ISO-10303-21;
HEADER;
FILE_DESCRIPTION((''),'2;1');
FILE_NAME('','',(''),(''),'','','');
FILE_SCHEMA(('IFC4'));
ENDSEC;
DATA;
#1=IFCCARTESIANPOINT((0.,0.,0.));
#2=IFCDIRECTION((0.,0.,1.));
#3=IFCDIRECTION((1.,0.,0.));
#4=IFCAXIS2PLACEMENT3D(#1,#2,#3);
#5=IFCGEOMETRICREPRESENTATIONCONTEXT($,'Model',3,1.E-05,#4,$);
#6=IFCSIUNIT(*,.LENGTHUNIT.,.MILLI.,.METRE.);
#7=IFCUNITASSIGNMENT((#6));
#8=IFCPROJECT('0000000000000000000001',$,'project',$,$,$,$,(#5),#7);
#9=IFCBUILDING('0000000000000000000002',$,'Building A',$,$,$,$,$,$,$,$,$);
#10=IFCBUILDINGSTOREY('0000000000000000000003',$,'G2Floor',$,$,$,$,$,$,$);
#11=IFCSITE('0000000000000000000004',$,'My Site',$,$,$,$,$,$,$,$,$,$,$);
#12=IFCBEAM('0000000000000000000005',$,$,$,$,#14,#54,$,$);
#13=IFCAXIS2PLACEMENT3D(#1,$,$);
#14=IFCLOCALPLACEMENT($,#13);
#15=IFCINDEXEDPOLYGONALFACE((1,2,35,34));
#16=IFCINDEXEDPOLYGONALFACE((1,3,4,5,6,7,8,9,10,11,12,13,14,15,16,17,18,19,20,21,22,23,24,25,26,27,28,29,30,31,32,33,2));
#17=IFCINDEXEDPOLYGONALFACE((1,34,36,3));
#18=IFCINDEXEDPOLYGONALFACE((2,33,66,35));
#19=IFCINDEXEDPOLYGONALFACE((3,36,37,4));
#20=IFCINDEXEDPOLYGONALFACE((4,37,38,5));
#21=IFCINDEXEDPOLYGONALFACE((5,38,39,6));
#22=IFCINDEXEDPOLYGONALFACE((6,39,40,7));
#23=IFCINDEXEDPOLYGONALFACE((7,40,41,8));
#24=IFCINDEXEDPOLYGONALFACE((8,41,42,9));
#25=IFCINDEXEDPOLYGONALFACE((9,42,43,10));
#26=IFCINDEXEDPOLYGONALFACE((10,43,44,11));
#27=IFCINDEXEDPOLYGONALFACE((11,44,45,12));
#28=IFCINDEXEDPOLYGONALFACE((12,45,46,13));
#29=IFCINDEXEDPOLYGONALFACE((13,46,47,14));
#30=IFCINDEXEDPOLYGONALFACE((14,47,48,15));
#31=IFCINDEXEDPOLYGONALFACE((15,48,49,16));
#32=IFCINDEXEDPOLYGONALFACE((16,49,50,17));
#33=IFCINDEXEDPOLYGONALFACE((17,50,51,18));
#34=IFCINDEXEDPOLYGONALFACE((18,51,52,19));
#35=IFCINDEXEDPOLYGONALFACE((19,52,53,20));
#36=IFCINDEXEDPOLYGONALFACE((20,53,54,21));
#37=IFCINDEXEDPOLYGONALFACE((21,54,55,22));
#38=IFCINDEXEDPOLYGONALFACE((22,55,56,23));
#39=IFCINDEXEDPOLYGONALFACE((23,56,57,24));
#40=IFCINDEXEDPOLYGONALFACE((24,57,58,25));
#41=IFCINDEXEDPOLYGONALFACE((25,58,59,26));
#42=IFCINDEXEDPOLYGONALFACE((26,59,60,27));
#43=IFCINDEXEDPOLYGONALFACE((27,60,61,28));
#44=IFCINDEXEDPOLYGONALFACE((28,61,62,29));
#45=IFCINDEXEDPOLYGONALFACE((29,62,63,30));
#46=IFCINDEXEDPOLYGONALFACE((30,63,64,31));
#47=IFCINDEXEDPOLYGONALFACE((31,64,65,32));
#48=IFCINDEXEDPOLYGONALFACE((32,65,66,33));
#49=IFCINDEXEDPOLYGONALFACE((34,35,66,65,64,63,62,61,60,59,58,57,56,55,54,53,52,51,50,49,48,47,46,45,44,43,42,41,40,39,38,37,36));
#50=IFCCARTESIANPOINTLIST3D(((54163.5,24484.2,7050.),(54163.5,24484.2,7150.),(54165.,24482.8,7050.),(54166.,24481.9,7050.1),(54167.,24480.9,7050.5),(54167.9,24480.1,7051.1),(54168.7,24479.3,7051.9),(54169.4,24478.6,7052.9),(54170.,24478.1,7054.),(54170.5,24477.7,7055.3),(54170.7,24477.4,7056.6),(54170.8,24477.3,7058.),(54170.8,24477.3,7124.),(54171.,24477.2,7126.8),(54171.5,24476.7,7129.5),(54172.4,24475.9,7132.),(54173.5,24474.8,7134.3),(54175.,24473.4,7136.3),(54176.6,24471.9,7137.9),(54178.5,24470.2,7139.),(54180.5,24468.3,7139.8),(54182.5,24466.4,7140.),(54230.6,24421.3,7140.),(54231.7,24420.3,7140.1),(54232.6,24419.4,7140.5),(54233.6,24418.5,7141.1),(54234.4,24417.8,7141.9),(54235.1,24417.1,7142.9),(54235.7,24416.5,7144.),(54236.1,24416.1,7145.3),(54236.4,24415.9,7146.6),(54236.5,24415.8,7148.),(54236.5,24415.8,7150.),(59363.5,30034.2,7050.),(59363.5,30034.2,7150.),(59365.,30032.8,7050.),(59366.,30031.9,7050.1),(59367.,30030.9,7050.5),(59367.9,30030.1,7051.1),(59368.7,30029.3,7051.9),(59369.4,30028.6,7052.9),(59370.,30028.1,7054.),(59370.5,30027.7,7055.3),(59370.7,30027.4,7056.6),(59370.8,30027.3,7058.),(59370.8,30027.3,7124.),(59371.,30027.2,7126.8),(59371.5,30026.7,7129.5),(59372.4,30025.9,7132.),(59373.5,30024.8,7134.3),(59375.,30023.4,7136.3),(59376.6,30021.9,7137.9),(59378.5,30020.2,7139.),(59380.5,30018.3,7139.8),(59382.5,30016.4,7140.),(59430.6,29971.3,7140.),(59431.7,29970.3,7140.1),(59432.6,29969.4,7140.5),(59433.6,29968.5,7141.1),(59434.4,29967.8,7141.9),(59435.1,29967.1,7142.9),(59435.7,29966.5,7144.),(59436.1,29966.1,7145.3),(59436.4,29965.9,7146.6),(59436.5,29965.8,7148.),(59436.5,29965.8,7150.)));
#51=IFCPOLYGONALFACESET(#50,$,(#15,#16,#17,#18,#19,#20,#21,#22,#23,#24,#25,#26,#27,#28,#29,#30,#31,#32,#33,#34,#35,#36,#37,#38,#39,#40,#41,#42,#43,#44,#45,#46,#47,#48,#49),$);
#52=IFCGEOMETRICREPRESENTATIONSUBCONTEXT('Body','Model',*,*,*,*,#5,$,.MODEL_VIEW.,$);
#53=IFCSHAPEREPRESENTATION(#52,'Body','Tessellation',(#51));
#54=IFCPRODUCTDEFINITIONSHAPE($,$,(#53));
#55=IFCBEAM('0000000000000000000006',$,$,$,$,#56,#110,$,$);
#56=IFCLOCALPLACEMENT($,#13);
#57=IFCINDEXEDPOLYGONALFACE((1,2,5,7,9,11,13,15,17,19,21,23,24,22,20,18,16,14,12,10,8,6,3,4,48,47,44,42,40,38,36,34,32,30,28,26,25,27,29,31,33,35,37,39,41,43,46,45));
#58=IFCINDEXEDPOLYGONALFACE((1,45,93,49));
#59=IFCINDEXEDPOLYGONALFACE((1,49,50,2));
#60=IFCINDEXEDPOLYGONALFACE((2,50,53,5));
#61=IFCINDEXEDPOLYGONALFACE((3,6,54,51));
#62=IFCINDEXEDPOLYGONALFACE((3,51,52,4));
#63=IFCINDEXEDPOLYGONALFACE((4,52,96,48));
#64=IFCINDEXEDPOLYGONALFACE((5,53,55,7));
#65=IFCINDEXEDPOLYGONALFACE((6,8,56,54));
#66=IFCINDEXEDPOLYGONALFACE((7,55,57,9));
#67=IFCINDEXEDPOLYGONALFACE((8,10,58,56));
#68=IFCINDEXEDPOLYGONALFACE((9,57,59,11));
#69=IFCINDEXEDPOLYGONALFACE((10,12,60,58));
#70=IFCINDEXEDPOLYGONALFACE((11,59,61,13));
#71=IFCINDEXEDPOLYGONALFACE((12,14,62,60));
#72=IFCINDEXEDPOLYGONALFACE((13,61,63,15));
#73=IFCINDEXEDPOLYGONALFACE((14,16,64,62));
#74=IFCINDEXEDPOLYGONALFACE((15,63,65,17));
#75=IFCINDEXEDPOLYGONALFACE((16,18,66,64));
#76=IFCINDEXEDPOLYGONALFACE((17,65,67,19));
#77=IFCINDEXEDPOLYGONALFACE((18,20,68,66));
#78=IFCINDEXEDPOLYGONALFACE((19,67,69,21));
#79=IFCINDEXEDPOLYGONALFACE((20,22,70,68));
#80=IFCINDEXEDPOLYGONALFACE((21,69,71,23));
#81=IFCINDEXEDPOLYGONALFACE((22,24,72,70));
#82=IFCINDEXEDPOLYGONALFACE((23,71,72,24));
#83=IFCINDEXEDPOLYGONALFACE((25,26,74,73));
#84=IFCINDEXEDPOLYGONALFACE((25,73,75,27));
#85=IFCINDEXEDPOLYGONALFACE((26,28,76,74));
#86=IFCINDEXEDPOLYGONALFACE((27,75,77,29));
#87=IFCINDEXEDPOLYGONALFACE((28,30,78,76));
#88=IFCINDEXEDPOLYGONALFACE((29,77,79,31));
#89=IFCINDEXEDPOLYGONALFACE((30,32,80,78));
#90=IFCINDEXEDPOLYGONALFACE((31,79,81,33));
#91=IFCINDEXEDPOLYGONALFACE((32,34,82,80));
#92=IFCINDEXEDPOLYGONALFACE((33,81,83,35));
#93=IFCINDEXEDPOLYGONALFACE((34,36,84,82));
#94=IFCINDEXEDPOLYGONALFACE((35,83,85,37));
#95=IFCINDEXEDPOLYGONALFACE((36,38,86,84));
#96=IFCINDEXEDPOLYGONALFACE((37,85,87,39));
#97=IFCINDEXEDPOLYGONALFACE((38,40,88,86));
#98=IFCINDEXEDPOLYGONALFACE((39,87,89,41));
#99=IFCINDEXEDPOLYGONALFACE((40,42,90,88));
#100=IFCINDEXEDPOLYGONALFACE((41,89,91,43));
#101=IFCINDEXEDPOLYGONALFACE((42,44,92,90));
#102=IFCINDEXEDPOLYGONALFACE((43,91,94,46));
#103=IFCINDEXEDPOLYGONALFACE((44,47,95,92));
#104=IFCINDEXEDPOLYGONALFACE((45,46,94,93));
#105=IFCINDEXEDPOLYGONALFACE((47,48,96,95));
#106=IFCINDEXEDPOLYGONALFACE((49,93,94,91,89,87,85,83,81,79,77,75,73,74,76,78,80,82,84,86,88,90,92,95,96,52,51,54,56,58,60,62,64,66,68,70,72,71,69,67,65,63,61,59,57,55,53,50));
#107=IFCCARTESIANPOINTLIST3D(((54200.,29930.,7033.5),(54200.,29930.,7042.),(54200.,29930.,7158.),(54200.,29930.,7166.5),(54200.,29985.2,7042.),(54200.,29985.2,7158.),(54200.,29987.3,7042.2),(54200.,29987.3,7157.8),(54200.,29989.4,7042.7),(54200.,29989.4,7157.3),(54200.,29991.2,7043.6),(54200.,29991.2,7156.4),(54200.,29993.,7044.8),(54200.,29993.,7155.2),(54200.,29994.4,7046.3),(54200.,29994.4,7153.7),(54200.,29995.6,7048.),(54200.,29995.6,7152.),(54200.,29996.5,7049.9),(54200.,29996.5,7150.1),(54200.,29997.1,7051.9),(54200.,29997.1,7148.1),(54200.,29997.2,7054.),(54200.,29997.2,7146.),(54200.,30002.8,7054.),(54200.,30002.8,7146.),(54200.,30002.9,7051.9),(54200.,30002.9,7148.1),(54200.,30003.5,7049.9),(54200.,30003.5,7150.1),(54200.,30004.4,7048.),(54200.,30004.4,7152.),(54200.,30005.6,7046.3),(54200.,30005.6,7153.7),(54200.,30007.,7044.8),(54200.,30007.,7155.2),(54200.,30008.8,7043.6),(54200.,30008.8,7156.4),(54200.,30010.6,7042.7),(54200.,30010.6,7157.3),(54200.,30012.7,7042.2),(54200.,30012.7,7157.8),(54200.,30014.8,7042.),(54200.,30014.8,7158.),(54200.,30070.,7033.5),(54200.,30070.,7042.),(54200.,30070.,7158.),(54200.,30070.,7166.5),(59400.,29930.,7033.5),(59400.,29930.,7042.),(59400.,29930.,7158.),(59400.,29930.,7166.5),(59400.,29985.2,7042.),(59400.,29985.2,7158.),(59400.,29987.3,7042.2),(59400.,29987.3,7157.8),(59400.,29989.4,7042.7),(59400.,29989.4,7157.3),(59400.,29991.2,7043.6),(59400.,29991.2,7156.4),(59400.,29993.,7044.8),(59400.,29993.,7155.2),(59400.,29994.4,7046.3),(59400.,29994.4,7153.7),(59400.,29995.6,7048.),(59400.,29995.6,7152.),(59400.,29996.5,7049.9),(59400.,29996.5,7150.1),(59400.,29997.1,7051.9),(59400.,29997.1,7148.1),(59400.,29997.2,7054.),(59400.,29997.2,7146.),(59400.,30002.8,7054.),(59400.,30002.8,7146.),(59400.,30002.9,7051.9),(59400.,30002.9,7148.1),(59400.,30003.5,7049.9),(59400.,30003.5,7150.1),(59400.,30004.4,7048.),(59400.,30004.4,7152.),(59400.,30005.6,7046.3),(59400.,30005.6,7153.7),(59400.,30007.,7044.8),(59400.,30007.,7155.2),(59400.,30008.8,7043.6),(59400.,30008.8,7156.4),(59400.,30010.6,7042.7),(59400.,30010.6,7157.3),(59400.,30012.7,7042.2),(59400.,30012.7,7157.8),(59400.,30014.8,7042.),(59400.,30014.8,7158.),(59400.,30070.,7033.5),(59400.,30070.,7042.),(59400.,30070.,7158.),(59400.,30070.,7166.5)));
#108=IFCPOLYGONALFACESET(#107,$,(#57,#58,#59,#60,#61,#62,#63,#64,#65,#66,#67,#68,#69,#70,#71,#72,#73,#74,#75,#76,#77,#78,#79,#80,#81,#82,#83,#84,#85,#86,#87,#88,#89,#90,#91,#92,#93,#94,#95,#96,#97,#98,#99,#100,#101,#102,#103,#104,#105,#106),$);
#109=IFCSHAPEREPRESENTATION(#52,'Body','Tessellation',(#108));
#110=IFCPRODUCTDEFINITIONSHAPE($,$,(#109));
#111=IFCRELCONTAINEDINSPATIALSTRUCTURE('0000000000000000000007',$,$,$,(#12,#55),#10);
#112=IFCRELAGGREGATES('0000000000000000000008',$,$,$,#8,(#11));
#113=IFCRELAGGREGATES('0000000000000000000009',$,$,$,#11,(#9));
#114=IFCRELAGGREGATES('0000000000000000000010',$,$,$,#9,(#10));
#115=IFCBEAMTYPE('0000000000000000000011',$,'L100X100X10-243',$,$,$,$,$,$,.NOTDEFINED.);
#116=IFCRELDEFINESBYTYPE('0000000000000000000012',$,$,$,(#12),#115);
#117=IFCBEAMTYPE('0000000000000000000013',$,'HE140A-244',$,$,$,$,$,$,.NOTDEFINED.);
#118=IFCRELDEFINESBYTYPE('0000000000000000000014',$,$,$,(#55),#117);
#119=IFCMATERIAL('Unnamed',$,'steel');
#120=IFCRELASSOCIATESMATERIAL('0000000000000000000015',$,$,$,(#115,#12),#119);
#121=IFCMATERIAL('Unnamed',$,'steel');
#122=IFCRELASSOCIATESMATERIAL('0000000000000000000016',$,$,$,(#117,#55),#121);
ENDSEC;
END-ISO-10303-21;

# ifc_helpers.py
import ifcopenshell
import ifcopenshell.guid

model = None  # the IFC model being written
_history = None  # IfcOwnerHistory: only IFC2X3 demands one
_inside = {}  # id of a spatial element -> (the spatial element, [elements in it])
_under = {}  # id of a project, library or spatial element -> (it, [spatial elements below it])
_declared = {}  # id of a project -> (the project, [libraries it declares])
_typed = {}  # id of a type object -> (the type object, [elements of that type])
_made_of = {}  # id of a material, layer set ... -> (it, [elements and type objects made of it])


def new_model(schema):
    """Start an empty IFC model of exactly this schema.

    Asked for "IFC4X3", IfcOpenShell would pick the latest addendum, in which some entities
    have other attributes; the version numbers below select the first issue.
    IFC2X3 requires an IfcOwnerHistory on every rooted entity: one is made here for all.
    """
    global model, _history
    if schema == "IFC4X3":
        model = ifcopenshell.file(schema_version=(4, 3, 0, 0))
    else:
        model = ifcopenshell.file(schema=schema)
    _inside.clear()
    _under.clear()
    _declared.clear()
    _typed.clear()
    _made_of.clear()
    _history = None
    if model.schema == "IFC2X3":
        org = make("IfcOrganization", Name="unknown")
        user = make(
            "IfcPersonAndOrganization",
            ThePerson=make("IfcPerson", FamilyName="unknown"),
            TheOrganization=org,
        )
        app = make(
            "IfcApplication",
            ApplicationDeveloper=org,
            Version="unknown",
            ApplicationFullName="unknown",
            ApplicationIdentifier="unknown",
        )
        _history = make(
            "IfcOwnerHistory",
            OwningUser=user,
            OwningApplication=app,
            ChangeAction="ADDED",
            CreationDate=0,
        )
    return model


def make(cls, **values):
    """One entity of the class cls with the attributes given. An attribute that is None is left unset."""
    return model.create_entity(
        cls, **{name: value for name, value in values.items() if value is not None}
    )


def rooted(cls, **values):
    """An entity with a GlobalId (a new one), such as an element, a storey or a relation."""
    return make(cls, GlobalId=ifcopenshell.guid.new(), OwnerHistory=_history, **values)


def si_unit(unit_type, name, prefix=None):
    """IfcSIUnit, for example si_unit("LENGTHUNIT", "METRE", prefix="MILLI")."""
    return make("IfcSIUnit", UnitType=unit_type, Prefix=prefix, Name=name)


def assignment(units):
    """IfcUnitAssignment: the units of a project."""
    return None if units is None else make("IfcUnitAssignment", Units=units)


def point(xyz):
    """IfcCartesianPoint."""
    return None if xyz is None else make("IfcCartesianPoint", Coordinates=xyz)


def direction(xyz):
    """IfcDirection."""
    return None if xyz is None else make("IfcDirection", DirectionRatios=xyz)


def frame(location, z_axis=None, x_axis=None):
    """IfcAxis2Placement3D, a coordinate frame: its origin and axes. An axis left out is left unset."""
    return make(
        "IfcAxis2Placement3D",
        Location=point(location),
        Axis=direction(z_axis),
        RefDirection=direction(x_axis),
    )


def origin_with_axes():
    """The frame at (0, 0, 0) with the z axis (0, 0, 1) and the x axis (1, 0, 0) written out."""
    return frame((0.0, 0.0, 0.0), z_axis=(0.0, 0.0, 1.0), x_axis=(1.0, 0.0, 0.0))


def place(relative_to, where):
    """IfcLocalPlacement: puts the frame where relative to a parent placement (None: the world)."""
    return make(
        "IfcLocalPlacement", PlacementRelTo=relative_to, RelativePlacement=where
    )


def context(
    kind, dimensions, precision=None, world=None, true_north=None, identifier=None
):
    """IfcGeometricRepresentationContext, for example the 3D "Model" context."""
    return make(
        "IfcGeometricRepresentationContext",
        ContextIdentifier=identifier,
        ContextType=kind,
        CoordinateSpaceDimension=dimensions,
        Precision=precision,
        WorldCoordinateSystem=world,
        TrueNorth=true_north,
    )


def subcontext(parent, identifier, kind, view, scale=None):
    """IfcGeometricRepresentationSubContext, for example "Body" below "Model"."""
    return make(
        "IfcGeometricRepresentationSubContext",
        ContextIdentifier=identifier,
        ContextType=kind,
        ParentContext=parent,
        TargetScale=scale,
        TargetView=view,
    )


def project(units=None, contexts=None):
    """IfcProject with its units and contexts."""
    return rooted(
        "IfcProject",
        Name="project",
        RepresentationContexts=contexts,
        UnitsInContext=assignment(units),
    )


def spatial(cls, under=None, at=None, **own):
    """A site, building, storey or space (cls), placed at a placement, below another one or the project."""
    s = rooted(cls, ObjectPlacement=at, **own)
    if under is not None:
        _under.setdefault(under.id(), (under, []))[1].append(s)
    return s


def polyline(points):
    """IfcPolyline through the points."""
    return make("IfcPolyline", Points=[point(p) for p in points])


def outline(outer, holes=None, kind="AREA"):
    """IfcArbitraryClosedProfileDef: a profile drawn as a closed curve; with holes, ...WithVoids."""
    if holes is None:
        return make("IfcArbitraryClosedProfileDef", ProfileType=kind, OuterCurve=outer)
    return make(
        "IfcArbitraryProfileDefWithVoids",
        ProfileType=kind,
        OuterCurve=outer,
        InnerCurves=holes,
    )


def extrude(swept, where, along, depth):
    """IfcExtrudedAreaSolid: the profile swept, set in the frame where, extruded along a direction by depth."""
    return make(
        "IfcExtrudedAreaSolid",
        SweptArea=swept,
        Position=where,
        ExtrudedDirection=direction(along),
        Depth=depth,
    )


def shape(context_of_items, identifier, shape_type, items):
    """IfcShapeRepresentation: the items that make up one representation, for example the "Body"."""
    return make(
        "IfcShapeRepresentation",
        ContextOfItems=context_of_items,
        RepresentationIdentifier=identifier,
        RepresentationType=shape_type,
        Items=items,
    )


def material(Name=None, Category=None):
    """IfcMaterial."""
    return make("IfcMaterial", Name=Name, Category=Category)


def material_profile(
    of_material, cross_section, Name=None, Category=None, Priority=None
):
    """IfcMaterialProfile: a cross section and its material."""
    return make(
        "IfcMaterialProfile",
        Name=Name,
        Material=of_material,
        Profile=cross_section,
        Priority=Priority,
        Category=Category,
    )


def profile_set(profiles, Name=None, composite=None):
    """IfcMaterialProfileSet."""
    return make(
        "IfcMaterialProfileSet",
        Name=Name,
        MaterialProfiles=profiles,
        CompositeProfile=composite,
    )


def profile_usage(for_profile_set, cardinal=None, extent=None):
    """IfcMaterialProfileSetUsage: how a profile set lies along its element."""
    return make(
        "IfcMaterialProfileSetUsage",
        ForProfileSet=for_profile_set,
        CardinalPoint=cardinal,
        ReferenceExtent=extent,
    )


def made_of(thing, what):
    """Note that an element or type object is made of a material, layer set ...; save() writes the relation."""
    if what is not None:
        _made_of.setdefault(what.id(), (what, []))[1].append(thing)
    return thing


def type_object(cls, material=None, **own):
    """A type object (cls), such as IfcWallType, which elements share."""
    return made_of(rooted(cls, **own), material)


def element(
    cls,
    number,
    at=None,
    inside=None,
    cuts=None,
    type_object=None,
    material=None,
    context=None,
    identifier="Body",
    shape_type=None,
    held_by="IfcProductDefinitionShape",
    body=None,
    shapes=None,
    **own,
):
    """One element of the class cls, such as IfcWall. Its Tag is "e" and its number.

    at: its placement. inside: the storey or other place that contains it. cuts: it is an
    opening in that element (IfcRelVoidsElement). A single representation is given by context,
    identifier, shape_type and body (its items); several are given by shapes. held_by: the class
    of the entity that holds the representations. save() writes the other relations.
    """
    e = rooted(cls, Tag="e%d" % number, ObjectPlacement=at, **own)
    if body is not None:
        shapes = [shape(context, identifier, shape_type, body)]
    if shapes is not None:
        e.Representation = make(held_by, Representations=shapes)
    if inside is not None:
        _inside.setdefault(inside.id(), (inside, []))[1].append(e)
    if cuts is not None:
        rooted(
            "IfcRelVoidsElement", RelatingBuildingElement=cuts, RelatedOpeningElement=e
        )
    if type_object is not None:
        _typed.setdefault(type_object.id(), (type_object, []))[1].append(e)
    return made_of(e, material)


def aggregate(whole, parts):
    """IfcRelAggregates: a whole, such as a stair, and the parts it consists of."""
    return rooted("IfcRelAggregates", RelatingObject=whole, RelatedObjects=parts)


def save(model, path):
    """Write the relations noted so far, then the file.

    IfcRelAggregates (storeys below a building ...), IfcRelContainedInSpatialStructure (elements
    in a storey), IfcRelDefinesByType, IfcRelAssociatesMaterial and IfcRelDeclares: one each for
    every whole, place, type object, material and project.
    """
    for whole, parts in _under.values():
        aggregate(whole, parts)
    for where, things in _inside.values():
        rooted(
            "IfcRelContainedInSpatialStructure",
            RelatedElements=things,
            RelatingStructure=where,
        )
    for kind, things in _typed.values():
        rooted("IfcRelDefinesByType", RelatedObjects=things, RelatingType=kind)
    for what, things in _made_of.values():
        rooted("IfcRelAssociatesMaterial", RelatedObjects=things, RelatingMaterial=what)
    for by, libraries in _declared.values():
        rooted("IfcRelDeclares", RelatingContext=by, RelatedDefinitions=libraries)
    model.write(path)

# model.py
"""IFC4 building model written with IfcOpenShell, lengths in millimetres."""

from ifc_helpers import new_model, si_unit, frame, origin_with_axes, place, context, subcontext, project, spatial, polyline, outline, extrude, material, material_profile, profile_set, profile_usage, type_object, element, save


model = new_model("IFC4")

# Units and contexts
model_context = context("Model", 3, precision=1e-05, world=origin_with_axes())
body_context = subcontext(model_context, "Body", "Model", "MODEL_VIEW")
ifc_project = project(units=[si_unit("LENGTHUNIT", "METRE", prefix="MILLI")], contexts=[model_context])

# Site, building, storey
site = spatial("IfcSite", under=ifc_project, Name="My Site")
building = spatial("IfcBuilding", under=site, Name="Building A")
storey = spatial("IfcBuildingStorey", under=building, Name="G2Floor")

# Beams
ifc_material_1 = material(Name="Unnamed", Category="steel")
ifc_material_profile_1 = material_profile(ifc_material_1, outline(polyline([(-50.0, -50.0), (50.0, -50.0), (50.0, -50.0), (50.0, -48.0), (50.0, -48.0), (49.9, -46.6), (49.9, -46.6), (49.5, -45.3), (49.5, -45.3), (48.9, -44.0), (48.9, -44.0), (48.1, -42.9), (48.1, -42.9), (47.1, -41.9), (47.1, -41.9), (46.0, -41.1), (46.0, -41.1), (44.7, -40.5), (44.7, -40.5), (43.4, -40.1), (43.4, -40.1), (42.0, -40.0), (42.0, -40.0), (-24.0, -40.0), (-24.0, -40.0), (-26.8, -39.8), (-26.8, -39.8), (-29.5, -39.0), (-29.5, -39.0), (-32.0, -37.9), (-32.0, -37.9), (-34.3, -36.3), (-34.3, -36.3), (-36.3, -34.3), (-36.3, -34.3), (-37.9, -32.0), (-37.9, -32.0), (-39.0, -29.5), (-39.0, -29.5), (-39.8, -26.8), (-39.8, -26.8), (-40.0, -24.0), (-40.0, -24.0), (-40.0, 42.0), (-40.0, 42.0), (-40.1, 43.4), (-40.1, 43.4), (-40.5, 44.7), (-40.5, 44.7), (-41.1, 46.0), (-41.1, 46.0), (-41.9, 47.1), (-41.9, 47.1), (-42.9, 48.1), (-42.9, 48.1), (-44.0, 48.9), (-44.0, 48.9), (-45.3, 49.5), (-45.3, 49.5), (-46.6, 49.9), (-46.6, 49.9), (-48.0, 50.0), (-48.0, 50.0), (-50.0, 50.0), (-50.0, 50.0), (-50.0, -50.0)])))
ifc_profile_set_1 = profile_set([ifc_material_profile_1], Name="L100X100X10-243")
ifc_profile_usage_1 = profile_usage(ifc_profile_set_1)
beam_type_1 = type_object("IfcBeamType", Name="L100X100X10-243", PredefinedType="NOTDEFINED", material=ifc_profile_set_1)
beam_1_placement = place(None, frame((54200.0, 24450.0, 7100.0), z_axis=(0.683722, 0.729742, 0.0), x_axis=(0.729742, -0.683722, 0.0)))
element("IfcBeam", 1, at=beam_1_placement, inside=storey, type_object=beam_type_1, material=ifc_profile_usage_1, context=body_context, shape_type="SweptSolid", body=[
    extrude(outline(polyline([(-50.0, -50.0), (50.0, -50.0), (50.0, -50.0), (50.0, -48.0), (50.0, -48.0), (49.9, -46.6), (49.9, -46.6), (49.5, -45.3), (49.5, -45.3), (48.9, -44.0), (48.9, -44.0), (48.1, -42.9), (48.1, -42.9), (47.1, -41.9), (47.1, -41.9), (46.0, -41.1), (46.0, -41.1), (44.7, -40.5), (44.7, -40.5), (43.4, -40.1), (43.4, -40.1), (42.0, -40.0), (42.0, -40.0), (-24.0, -40.0), (-24.0, -40.0), (-26.8, -39.8), (-26.8, -39.8), (-29.5, -39.0), (-29.5, -39.0), (-32.0, -37.9), (-32.0, -37.9), (-34.3, -36.3), (-34.3, -36.3), (-36.3, -34.3), (-36.3, -34.3), (-37.9, -32.0), (-37.9, -32.0), (-39.0, -29.5), (-39.0, -29.5), (-39.8, -26.8), (-39.8, -26.8), (-40.0, -24.0), (-40.0, -24.0), (-40.0, 42.0), (-40.0, 42.0), (-40.1, 43.4), (-40.1, 43.4), (-40.5, 44.7), (-40.5, 44.7), (-41.1, 46.0), (-41.1, 46.0), (-41.9, 47.1), (-41.9, 47.1), (-42.9, 48.1), (-42.9, 48.1), (-44.0, 48.9), (-44.0, 48.9), (-45.3, 49.5), (-45.3, 49.5), (-46.6, 49.9), (-46.6, 49.9), (-48.0, 50.0), (-48.0, 50.0), (-50.0, 50.0), (-50.0, 50.0), (-50.0, -50.0)])), origin_with_axes(), (0.0, 0.0, 1.0), 7605.4),
])
ifc_material_2 = material(Name="Unnamed", Category="steel")
ifc_material_profile_2 = material_profile(ifc_material_2, outline(polyline([(70.0, -66.5), (70.0, -58.0), (70.0, -58.0), (14.8, -58.0), (14.8, -58.0), (12.7, -57.8), (12.7, -57.8), (10.6, -57.3), (10.6, -57.3), (8.8, -56.4), (8.8, -56.4), (7.0, -55.2), (7.0, -55.2), (5.6, -53.7), (5.6, -53.7), (4.4, -52.0), (4.4, -52.0), (3.5, -50.1), (3.5, -50.1), (2.9, -48.1), (2.9, -48.1), (2.8, -46.0), (2.8, -46.0), (2.8, 46.0), (2.8, 46.0), (2.9, 48.1), (2.9, 48.1), (3.5, 50.1), (3.5, 50.1), (4.4, 52.0), (4.4, 52.0), (5.6, 53.7), (5.6, 53.7), (7.0, 55.2), (7.0, 55.2), (8.8, 56.4), (8.8, 56.4), (10.6, 57.3), (10.6, 57.3), (12.7, 57.8), (12.7, 57.8), (14.8, 58.0), (14.8, 58.0), (70.0, 58.0), (70.0, 58.0), (70.0, 66.5), (70.0, 66.5), (-70.0, 66.5), (-70.0, 66.5), (-70.0, 58.0), (-70.0, 58.0), (-14.8, 58.0), (-14.8, 58.0), (-12.7, 57.8), (-12.7, 57.8), (-10.6, 57.3), (-10.6, 57.3), (-8.8, 56.4), (-8.8, 56.4), (-7.0, 55.2), (-7.0, 55.2), (-5.6, 53.7), (-5.6, 53.7), (-4.4, 52.0), (-4.4, 52.0), (-3.5, 50.1), (-3.5, 50.1), (-2.9, 48.1), (-2.9, 48.1), (-2.8, 46.0), (-2.8, 46.0), (-2.8, -46.0), (-2.8, -46.0), (-2.9, -48.1), (-2.9, -48.1), (-3.5, -50.1), (-3.5, -50.1), (-4.4, -52.0), (-4.4, -52.0), (-5.6, -53.7), (-5.6, -53.7), (-7.0, -55.2), (-7.0, -55.2), (-8.8, -56.4), (-8.8, -56.4), (-10.6, -57.3), (-10.6, -57.3), (-12.7, -57.8), (-12.7, -57.8), (-14.8, -58.0), (-14.8, -58.0), (-70.0, -58.0), (-70.0, -58.0), (-70.0, -66.5), (-70.0, -66.5), (70.0, -66.5)])))
ifc_profile_set_2 = profile_set([ifc_material_profile_2], Name="HE140A-244")
ifc_profile_usage_2 = profile_usage(ifc_profile_set_2)
beam_type_2 = type_object("IfcBeamType", Name="HE140A-244", PredefinedType="NOTDEFINED", material=ifc_profile_set_2)
beam_2_placement = place(None, frame((54200.0, 30000.0, 7100.0), z_axis=(1.0, 0.0, 0.0), x_axis=(0.0, -1.0, 0.0)))
element("IfcBeam", 2, at=beam_2_placement, inside=storey, type_object=beam_type_2, material=ifc_profile_usage_2, context=body_context, shape_type="SweptSolid", body=[
    extrude(outline(polyline([(70.0, -66.5), (70.0, -58.0), (70.0, -58.0), (14.8, -58.0), (14.8, -58.0), (12.7, -57.8), (12.7, -57.8), (10.6, -57.3), (10.6, -57.3), (8.8, -56.4), (8.8, -56.4), (7.0, -55.2), (7.0, -55.2), (5.6, -53.7), (5.6, -53.7), (4.4, -52.0), (4.4, -52.0), (3.5, -50.1), (3.5, -50.1), (2.9, -48.1), (2.9, -48.1), (2.8, -46.0), (2.8, -46.0), (2.8, 46.0), (2.8, 46.0), (2.9, 48.1), (2.9, 48.1), (3.5, 50.1), (3.5, 50.1), (4.4, 52.0), (4.4, 52.0), (5.6, 53.7), (5.6, 53.7), (7.0, 55.2), (7.0, 55.2), (8.8, 56.4), (8.8, 56.4), (10.6, 57.3), (10.6, 57.3), (12.7, 57.8), (12.7, 57.8), (14.8, 58.0), (14.8, 58.0), (70.0, 58.0), (70.0, 58.0), (70.0, 66.5), (70.0, 66.5), (-70.0, 66.5), (-70.0, 66.5), (-70.0, 58.0), (-70.0, 58.0), (-14.8, 58.0), (-14.8, 58.0), (-12.7, 57.8), (-12.7, 57.8), (-10.6, 57.3), (-10.6, 57.3), (-8.8, 56.4), (-8.8, 56.4), (-7.0, 55.2), (-7.0, 55.2), (-5.6, 53.7), (-5.6, 53.7), (-4.4, 52.0), (-4.4, 52.0), (-3.5, 50.1), (-3.5, 50.1), (-2.9, 48.1), (-2.9, 48.1), (-2.8, 46.0), (-2.8, 46.0), (-2.8, -46.0), (-2.8, -46.0), (-2.9, -48.1), (-2.9, -48.1), (-3.5, -50.1), (-3.5, -50.1), (-4.4, -52.0), (-4.4, -52.0), (-5.6, -53.7), (-5.6, -53.7), (-7.0, -55.2), (-7.0, -55.2), (-8.8, -56.4), (-8.8, -56.4), (-10.6, -57.3), (-10.6, -57.3), (-12.7, -57.8), (-12.7, -57.8), (-14.8, -58.0), (-14.8, -58.0), (-70.0, -58.0), (-70.0, -58.0), (-70.0, -66.5), (-70.0, -66.5), (70.0, -66.5)])), origin_with_axes(), (0.0, 0.0, 1.0), 5200.0),
])

save(model, "model.ifc")
